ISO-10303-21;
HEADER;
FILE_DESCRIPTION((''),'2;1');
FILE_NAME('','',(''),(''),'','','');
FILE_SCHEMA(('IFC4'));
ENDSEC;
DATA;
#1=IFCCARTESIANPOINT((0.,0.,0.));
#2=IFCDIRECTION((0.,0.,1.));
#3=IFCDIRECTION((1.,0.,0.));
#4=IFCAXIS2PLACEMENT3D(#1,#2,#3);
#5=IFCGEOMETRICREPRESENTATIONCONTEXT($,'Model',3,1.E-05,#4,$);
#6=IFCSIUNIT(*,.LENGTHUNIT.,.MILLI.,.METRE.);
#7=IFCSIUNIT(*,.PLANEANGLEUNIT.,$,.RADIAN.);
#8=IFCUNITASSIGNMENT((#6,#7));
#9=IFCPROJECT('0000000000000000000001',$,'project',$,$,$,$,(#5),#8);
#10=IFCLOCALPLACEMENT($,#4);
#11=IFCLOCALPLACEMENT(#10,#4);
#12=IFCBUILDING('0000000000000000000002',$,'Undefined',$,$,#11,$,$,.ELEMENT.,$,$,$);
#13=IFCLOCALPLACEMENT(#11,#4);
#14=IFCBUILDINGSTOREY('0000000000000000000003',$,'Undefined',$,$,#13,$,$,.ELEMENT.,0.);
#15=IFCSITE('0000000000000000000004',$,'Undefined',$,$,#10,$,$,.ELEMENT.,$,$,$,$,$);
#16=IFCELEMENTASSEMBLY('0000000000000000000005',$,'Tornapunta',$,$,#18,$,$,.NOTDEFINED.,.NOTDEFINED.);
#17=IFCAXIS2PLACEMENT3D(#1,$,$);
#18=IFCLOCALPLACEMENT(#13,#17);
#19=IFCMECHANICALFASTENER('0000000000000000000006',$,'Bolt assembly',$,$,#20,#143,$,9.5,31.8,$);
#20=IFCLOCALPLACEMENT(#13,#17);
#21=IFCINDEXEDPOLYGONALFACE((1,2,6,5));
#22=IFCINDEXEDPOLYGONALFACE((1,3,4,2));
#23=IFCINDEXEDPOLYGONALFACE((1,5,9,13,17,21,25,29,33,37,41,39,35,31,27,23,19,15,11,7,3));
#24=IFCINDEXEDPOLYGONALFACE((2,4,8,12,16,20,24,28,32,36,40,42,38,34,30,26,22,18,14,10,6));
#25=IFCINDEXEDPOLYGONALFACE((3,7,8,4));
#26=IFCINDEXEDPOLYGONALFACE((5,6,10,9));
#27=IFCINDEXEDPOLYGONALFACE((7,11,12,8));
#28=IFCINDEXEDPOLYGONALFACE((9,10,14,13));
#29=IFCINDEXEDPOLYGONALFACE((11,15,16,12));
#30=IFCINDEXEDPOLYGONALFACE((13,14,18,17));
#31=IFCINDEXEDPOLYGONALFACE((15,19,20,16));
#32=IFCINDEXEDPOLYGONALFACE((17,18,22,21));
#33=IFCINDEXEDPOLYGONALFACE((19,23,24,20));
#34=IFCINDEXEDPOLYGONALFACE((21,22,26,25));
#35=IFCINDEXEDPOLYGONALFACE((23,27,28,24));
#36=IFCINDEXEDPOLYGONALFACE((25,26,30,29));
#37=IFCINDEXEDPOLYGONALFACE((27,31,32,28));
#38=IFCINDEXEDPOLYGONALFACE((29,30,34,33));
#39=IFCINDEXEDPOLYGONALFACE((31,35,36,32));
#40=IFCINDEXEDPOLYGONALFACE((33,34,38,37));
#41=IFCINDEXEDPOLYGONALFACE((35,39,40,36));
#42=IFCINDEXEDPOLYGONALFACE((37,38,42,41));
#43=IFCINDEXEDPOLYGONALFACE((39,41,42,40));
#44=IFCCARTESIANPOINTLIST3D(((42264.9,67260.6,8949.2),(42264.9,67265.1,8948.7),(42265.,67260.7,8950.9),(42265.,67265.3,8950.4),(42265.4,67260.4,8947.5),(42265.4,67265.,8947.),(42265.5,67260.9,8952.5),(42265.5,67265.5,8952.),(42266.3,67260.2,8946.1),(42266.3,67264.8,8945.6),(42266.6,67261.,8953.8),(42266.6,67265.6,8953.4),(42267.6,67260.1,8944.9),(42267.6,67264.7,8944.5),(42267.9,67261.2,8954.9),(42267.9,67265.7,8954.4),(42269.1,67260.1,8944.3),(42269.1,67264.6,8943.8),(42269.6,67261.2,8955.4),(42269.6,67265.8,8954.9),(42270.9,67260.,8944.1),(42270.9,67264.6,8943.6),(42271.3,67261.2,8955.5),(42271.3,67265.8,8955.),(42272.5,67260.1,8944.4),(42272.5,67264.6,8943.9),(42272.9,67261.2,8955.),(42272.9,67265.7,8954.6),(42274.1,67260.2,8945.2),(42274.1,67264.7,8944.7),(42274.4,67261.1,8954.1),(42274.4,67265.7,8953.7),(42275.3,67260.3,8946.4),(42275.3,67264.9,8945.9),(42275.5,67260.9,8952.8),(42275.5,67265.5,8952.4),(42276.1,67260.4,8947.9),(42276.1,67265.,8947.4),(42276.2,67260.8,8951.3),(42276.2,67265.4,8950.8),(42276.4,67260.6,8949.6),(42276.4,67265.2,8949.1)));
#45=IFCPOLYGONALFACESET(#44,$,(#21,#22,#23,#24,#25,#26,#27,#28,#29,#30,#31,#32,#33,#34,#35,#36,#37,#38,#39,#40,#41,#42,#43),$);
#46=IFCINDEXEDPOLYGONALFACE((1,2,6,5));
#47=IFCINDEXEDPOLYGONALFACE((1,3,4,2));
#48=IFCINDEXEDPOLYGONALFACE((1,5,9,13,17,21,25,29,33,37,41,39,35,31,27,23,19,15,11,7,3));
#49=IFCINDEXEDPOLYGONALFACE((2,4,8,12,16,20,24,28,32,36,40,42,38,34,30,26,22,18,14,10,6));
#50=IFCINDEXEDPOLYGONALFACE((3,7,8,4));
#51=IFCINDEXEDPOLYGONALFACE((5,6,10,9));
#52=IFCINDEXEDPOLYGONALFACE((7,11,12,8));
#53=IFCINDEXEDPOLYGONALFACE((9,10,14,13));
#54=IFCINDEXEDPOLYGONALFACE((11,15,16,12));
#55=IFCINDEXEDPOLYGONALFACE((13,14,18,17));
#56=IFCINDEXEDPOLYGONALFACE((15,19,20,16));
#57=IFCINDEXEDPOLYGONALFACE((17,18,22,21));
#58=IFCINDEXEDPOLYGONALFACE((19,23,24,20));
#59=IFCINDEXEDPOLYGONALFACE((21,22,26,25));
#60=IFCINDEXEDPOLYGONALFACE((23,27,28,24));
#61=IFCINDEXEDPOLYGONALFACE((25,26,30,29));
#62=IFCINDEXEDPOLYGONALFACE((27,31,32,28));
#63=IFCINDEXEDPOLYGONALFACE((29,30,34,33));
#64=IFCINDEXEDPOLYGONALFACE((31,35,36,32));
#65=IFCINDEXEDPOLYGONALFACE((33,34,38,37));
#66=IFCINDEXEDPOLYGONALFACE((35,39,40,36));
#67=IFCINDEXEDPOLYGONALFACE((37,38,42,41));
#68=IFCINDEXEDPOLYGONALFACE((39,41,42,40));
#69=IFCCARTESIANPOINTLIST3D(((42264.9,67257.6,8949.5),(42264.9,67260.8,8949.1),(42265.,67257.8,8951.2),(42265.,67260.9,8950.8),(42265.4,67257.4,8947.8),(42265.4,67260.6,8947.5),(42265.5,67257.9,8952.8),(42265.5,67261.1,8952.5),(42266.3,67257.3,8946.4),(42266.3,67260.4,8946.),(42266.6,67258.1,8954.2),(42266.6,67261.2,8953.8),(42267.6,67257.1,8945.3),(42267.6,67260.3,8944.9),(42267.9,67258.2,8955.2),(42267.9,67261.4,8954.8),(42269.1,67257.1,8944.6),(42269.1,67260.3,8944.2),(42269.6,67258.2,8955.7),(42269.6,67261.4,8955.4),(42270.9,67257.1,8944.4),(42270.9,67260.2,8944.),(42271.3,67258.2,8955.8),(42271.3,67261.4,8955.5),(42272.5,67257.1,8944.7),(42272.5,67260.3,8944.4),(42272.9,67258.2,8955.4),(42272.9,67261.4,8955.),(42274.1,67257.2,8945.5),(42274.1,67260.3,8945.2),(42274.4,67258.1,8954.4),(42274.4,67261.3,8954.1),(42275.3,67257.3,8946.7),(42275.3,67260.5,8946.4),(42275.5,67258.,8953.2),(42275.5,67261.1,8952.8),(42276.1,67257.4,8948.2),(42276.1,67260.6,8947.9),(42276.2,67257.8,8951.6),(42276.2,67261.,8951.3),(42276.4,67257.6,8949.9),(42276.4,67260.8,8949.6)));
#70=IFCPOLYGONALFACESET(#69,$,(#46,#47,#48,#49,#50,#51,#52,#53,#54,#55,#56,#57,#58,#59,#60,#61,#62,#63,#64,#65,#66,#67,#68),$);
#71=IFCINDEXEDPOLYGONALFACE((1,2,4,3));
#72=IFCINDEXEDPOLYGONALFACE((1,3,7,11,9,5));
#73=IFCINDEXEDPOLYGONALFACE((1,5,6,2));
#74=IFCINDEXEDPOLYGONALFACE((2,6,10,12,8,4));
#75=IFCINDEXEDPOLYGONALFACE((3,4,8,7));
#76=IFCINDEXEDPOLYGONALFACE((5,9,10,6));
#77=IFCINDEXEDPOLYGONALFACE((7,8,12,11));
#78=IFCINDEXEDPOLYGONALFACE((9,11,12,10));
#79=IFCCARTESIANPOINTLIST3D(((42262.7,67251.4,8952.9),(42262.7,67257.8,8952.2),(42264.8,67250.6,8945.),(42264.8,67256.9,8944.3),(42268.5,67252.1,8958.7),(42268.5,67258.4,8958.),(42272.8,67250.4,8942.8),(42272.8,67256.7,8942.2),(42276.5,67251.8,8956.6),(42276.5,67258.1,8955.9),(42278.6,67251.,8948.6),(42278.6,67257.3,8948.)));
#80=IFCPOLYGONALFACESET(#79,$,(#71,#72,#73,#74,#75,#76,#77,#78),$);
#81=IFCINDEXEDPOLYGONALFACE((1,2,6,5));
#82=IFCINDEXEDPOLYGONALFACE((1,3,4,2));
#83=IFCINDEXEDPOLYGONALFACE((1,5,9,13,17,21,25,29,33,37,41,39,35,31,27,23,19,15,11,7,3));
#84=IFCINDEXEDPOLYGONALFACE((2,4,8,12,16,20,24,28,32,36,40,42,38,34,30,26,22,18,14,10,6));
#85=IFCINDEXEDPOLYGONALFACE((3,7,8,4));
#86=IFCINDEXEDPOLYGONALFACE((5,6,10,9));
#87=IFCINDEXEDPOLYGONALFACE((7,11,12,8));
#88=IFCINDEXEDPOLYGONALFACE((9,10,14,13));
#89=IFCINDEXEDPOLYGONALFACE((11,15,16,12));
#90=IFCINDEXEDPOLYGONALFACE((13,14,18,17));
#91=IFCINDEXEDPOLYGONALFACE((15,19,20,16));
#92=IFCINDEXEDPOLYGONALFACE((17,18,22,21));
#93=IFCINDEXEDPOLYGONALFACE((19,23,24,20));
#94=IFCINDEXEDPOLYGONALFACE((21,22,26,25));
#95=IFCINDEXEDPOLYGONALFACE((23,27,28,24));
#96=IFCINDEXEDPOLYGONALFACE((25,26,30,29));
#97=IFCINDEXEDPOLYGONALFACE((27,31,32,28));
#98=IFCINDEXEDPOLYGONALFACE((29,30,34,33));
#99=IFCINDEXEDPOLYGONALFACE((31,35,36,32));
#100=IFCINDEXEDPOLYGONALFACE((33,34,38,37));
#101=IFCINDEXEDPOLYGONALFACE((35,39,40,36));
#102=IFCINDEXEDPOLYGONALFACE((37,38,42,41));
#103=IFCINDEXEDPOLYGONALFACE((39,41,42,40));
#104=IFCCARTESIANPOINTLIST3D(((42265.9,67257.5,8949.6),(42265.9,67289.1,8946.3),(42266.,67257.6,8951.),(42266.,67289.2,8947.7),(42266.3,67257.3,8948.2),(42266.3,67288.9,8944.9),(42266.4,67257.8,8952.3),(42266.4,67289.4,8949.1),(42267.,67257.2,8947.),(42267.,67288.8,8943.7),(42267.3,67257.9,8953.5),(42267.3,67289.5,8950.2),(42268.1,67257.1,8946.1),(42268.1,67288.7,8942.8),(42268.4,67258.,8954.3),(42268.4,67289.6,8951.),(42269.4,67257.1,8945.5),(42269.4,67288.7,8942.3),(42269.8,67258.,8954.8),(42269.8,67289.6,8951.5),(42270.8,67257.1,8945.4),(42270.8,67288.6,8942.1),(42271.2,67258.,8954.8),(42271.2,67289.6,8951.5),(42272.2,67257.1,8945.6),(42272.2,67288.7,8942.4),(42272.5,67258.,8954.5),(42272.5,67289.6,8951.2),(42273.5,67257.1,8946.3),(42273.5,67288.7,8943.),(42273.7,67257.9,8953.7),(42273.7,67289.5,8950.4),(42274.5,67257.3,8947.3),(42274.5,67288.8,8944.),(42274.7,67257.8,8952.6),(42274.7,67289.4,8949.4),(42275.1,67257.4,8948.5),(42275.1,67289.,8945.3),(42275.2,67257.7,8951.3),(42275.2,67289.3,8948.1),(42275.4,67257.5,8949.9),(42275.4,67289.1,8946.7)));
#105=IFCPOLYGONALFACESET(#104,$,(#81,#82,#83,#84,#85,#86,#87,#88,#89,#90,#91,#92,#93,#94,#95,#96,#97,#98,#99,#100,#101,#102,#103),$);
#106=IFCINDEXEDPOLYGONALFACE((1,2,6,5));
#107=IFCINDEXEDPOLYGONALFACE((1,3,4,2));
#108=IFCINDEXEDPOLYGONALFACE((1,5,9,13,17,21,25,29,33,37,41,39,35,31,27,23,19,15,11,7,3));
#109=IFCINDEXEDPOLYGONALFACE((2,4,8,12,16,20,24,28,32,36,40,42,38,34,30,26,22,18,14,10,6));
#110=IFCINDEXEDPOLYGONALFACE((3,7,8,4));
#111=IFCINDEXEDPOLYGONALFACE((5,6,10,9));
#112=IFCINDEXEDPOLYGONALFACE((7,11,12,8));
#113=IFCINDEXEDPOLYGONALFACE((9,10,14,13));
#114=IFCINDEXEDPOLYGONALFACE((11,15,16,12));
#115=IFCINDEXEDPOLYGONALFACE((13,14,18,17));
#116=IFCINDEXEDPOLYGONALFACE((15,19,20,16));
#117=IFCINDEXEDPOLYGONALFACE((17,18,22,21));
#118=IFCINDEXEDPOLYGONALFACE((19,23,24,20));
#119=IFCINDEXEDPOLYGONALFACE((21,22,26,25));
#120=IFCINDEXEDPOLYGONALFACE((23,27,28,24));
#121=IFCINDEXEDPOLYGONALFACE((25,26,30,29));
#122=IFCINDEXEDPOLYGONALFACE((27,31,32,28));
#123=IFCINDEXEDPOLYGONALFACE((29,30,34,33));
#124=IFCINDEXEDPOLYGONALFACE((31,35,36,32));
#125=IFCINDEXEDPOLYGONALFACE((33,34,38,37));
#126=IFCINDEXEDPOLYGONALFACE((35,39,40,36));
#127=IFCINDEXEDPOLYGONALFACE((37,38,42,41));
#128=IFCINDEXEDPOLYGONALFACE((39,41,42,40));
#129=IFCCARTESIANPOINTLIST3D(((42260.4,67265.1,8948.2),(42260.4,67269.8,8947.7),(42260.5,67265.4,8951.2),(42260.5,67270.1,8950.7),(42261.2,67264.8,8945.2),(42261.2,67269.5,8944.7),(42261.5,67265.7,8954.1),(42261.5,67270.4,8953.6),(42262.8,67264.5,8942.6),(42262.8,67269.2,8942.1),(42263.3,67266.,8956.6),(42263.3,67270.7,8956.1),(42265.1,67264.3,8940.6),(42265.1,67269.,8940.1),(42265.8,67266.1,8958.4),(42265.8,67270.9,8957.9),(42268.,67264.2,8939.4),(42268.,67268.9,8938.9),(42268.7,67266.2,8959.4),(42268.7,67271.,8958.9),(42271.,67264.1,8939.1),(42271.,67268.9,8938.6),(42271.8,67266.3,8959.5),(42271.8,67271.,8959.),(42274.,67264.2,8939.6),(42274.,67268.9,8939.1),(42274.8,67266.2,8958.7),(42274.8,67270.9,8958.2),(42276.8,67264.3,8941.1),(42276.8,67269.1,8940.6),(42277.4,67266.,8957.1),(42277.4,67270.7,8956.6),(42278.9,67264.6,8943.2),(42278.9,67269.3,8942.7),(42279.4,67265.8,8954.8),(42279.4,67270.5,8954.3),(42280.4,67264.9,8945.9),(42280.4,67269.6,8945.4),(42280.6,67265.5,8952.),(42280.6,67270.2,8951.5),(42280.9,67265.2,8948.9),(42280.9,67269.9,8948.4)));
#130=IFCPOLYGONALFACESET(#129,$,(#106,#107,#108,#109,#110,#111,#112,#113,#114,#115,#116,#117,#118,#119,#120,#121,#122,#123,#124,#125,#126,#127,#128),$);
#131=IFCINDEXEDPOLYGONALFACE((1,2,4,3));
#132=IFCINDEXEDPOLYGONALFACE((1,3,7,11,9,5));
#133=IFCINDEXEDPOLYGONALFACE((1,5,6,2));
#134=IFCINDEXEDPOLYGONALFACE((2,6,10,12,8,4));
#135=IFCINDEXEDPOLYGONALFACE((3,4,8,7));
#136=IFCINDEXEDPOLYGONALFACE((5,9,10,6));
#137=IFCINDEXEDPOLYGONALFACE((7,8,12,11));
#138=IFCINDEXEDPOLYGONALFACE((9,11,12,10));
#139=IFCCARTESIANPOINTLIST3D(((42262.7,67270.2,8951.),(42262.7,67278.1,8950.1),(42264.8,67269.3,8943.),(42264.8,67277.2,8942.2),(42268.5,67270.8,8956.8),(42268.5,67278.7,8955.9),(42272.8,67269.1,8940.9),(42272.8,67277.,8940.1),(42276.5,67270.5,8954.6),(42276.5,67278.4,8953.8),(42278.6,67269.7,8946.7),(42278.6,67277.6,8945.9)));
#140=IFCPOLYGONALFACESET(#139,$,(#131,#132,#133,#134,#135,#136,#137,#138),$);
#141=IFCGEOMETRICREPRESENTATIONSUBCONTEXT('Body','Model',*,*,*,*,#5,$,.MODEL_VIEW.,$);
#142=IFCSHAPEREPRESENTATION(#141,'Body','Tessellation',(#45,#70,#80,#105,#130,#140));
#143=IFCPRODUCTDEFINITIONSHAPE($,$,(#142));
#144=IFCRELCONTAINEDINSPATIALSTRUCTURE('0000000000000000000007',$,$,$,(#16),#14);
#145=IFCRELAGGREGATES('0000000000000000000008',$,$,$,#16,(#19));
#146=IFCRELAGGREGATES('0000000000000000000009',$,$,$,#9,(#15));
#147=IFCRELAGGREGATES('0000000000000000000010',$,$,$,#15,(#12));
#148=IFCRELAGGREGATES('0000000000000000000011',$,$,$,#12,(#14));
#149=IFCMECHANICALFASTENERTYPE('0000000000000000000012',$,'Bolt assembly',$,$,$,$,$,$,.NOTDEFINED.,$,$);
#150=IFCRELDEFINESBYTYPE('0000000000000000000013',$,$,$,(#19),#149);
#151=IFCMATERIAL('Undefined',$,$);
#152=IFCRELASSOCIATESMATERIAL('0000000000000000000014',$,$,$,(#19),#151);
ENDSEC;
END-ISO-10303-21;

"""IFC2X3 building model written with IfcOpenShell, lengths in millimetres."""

from ifc_helpers import new_model, si_unit, frame, origin_with_axes, origin_2d_with_axis, place, context, subcontext, project, spatial, polyline, circle, outline, extrude, source, transform, mapped, material, type_object, element, aggregate, save


model = new_model("IFC2X3")

# Units and contexts
model_context = context("Model", 3, precision=1e-05, world=origin_with_axes())
body_context = subcontext(model_context, "Body", "Model", "MODEL_VIEW")
ifc_project = project(units=[si_unit("LENGTHUNIT", "METRE", prefix="MILLI"), si_unit("PLANEANGLEUNIT", "RADIAN")], contexts=[model_context])

# Site, building, storey
site_placement = place(None, origin_with_axes())
site = spatial("IfcSite", under=ifc_project, at=site_placement, Name="Undefined", CompositionType="ELEMENT")
building_placement = place(site_placement, origin_with_axes())
building = spatial("IfcBuilding", under=site, at=building_placement, Name="Undefined", CompositionType="ELEMENT")
storey_placement = place(building_placement, origin_with_axes())
storey = spatial("IfcBuildingStorey", under=building, at=storey_placement, Name="Undefined", CompositionType="ELEMENT", Elevation=0.0)

# Element assembly
assembly_1_placement = place(storey_placement, origin_with_axes())
assembly_1 = element("IfcElementAssembly", 1, at=assembly_1_placement, inside=storey, Name="Tornapunta", AssemblyPlace="NOTDEFINED", PredefinedType="NOTDEFINED")

# Shared definitions
ifc_material_1 = material(Name="Undefined")
mechanical_fastener_type = type_object("IfcMechanicalFastenerType", Name="Bolt assembly")

# Mechanical fastener
shared_shape_1 = source(origin_with_axes(), body_context, "Body", "SweptSolid", [
    extrude(circle(Radius=5.8, at=origin_2d_with_axis()), frame((0.0, -0.1, 0.0), z_axis=(0.0, 1.0, 0.0), x_axis=(1.0, 0.0, 0.0)), (0.0, 0.0, 1.0), 4.6),
    extrude(circle(Radius=5.8, at=origin_2d_with_axis()), frame((0.0, -3.1, 0.0), z_axis=(0.0, 1.0, 0.0), x_axis=(1.0, 0.0, 0.0)), (0.0, 0.0, 1.0), 3.2),
    extrude(outline(polyline([(7.1, -4.1), (7.1, 4.1), (0.0, 8.2), (-7.1, 4.1), (-7.1, -4.1), (0.0, -8.2), (7.1, -4.1)])), frame((0.0, -9.5, 0.0), z_axis=(0.0, 1.0, 0.0), x_axis=(1.0, 0.0, 0.0)), (0.0, 0.0, 1.0), 6.3),
    extrude(circle(Radius=4.8, at=origin_2d_with_axis()), frame((0.0, -3.2, 0.0), z_axis=(0.0, 1.0, 0.0), x_axis=(1.0, 0.0, 0.0)), (0.0, 0.0, 1.0), 31.8),
    extrude(circle(Radius=10.3, at=origin_2d_with_axis()), frame((0.0, 4.5, 0.0), z_axis=(0.0, 1.0, 0.0), x_axis=(1.0, 0.0, 0.0)), (0.0, 0.0, 1.0), 4.8),
    extrude(outline(polyline([(7.1, -4.1), (7.1, 4.1), (0.0, 8.2), (-7.1, 4.1), (-7.1, -4.1), (0.0, -8.2), (7.1, -4.1)])), frame((0.0, 9.3, 0.0), z_axis=(0.0, 1.0, 0.0), x_axis=(1.0, 0.0, 0.0)), (0.0, 0.0, 1.0), 7.9),
])
mechanical_fastener_1_placement = place(assembly_1_placement, frame((42270.6, 67260.7, 8949.8), z_axis=(-0.707107, -0.072947, -0.703334), x_axis=(-0.707107, 0.072947, 0.703334)))
mechanical_fastener_1 = element("IfcMechanicalFastener", 2, at=mechanical_fastener_1_placement, type_object=mechanical_fastener_type, material=ifc_material_1, Name="Bolt assembly", NominalDiameter=9.5, NominalLength=31.8, context=body_context, shape_type="MappedRepresentation", body=[
    mapped(shared_shape_1, transform((0.0, 0.0, 0.0))),
])
aggregate(assembly_1, [mechanical_fastener_1])

save(model, "model.ifc")
